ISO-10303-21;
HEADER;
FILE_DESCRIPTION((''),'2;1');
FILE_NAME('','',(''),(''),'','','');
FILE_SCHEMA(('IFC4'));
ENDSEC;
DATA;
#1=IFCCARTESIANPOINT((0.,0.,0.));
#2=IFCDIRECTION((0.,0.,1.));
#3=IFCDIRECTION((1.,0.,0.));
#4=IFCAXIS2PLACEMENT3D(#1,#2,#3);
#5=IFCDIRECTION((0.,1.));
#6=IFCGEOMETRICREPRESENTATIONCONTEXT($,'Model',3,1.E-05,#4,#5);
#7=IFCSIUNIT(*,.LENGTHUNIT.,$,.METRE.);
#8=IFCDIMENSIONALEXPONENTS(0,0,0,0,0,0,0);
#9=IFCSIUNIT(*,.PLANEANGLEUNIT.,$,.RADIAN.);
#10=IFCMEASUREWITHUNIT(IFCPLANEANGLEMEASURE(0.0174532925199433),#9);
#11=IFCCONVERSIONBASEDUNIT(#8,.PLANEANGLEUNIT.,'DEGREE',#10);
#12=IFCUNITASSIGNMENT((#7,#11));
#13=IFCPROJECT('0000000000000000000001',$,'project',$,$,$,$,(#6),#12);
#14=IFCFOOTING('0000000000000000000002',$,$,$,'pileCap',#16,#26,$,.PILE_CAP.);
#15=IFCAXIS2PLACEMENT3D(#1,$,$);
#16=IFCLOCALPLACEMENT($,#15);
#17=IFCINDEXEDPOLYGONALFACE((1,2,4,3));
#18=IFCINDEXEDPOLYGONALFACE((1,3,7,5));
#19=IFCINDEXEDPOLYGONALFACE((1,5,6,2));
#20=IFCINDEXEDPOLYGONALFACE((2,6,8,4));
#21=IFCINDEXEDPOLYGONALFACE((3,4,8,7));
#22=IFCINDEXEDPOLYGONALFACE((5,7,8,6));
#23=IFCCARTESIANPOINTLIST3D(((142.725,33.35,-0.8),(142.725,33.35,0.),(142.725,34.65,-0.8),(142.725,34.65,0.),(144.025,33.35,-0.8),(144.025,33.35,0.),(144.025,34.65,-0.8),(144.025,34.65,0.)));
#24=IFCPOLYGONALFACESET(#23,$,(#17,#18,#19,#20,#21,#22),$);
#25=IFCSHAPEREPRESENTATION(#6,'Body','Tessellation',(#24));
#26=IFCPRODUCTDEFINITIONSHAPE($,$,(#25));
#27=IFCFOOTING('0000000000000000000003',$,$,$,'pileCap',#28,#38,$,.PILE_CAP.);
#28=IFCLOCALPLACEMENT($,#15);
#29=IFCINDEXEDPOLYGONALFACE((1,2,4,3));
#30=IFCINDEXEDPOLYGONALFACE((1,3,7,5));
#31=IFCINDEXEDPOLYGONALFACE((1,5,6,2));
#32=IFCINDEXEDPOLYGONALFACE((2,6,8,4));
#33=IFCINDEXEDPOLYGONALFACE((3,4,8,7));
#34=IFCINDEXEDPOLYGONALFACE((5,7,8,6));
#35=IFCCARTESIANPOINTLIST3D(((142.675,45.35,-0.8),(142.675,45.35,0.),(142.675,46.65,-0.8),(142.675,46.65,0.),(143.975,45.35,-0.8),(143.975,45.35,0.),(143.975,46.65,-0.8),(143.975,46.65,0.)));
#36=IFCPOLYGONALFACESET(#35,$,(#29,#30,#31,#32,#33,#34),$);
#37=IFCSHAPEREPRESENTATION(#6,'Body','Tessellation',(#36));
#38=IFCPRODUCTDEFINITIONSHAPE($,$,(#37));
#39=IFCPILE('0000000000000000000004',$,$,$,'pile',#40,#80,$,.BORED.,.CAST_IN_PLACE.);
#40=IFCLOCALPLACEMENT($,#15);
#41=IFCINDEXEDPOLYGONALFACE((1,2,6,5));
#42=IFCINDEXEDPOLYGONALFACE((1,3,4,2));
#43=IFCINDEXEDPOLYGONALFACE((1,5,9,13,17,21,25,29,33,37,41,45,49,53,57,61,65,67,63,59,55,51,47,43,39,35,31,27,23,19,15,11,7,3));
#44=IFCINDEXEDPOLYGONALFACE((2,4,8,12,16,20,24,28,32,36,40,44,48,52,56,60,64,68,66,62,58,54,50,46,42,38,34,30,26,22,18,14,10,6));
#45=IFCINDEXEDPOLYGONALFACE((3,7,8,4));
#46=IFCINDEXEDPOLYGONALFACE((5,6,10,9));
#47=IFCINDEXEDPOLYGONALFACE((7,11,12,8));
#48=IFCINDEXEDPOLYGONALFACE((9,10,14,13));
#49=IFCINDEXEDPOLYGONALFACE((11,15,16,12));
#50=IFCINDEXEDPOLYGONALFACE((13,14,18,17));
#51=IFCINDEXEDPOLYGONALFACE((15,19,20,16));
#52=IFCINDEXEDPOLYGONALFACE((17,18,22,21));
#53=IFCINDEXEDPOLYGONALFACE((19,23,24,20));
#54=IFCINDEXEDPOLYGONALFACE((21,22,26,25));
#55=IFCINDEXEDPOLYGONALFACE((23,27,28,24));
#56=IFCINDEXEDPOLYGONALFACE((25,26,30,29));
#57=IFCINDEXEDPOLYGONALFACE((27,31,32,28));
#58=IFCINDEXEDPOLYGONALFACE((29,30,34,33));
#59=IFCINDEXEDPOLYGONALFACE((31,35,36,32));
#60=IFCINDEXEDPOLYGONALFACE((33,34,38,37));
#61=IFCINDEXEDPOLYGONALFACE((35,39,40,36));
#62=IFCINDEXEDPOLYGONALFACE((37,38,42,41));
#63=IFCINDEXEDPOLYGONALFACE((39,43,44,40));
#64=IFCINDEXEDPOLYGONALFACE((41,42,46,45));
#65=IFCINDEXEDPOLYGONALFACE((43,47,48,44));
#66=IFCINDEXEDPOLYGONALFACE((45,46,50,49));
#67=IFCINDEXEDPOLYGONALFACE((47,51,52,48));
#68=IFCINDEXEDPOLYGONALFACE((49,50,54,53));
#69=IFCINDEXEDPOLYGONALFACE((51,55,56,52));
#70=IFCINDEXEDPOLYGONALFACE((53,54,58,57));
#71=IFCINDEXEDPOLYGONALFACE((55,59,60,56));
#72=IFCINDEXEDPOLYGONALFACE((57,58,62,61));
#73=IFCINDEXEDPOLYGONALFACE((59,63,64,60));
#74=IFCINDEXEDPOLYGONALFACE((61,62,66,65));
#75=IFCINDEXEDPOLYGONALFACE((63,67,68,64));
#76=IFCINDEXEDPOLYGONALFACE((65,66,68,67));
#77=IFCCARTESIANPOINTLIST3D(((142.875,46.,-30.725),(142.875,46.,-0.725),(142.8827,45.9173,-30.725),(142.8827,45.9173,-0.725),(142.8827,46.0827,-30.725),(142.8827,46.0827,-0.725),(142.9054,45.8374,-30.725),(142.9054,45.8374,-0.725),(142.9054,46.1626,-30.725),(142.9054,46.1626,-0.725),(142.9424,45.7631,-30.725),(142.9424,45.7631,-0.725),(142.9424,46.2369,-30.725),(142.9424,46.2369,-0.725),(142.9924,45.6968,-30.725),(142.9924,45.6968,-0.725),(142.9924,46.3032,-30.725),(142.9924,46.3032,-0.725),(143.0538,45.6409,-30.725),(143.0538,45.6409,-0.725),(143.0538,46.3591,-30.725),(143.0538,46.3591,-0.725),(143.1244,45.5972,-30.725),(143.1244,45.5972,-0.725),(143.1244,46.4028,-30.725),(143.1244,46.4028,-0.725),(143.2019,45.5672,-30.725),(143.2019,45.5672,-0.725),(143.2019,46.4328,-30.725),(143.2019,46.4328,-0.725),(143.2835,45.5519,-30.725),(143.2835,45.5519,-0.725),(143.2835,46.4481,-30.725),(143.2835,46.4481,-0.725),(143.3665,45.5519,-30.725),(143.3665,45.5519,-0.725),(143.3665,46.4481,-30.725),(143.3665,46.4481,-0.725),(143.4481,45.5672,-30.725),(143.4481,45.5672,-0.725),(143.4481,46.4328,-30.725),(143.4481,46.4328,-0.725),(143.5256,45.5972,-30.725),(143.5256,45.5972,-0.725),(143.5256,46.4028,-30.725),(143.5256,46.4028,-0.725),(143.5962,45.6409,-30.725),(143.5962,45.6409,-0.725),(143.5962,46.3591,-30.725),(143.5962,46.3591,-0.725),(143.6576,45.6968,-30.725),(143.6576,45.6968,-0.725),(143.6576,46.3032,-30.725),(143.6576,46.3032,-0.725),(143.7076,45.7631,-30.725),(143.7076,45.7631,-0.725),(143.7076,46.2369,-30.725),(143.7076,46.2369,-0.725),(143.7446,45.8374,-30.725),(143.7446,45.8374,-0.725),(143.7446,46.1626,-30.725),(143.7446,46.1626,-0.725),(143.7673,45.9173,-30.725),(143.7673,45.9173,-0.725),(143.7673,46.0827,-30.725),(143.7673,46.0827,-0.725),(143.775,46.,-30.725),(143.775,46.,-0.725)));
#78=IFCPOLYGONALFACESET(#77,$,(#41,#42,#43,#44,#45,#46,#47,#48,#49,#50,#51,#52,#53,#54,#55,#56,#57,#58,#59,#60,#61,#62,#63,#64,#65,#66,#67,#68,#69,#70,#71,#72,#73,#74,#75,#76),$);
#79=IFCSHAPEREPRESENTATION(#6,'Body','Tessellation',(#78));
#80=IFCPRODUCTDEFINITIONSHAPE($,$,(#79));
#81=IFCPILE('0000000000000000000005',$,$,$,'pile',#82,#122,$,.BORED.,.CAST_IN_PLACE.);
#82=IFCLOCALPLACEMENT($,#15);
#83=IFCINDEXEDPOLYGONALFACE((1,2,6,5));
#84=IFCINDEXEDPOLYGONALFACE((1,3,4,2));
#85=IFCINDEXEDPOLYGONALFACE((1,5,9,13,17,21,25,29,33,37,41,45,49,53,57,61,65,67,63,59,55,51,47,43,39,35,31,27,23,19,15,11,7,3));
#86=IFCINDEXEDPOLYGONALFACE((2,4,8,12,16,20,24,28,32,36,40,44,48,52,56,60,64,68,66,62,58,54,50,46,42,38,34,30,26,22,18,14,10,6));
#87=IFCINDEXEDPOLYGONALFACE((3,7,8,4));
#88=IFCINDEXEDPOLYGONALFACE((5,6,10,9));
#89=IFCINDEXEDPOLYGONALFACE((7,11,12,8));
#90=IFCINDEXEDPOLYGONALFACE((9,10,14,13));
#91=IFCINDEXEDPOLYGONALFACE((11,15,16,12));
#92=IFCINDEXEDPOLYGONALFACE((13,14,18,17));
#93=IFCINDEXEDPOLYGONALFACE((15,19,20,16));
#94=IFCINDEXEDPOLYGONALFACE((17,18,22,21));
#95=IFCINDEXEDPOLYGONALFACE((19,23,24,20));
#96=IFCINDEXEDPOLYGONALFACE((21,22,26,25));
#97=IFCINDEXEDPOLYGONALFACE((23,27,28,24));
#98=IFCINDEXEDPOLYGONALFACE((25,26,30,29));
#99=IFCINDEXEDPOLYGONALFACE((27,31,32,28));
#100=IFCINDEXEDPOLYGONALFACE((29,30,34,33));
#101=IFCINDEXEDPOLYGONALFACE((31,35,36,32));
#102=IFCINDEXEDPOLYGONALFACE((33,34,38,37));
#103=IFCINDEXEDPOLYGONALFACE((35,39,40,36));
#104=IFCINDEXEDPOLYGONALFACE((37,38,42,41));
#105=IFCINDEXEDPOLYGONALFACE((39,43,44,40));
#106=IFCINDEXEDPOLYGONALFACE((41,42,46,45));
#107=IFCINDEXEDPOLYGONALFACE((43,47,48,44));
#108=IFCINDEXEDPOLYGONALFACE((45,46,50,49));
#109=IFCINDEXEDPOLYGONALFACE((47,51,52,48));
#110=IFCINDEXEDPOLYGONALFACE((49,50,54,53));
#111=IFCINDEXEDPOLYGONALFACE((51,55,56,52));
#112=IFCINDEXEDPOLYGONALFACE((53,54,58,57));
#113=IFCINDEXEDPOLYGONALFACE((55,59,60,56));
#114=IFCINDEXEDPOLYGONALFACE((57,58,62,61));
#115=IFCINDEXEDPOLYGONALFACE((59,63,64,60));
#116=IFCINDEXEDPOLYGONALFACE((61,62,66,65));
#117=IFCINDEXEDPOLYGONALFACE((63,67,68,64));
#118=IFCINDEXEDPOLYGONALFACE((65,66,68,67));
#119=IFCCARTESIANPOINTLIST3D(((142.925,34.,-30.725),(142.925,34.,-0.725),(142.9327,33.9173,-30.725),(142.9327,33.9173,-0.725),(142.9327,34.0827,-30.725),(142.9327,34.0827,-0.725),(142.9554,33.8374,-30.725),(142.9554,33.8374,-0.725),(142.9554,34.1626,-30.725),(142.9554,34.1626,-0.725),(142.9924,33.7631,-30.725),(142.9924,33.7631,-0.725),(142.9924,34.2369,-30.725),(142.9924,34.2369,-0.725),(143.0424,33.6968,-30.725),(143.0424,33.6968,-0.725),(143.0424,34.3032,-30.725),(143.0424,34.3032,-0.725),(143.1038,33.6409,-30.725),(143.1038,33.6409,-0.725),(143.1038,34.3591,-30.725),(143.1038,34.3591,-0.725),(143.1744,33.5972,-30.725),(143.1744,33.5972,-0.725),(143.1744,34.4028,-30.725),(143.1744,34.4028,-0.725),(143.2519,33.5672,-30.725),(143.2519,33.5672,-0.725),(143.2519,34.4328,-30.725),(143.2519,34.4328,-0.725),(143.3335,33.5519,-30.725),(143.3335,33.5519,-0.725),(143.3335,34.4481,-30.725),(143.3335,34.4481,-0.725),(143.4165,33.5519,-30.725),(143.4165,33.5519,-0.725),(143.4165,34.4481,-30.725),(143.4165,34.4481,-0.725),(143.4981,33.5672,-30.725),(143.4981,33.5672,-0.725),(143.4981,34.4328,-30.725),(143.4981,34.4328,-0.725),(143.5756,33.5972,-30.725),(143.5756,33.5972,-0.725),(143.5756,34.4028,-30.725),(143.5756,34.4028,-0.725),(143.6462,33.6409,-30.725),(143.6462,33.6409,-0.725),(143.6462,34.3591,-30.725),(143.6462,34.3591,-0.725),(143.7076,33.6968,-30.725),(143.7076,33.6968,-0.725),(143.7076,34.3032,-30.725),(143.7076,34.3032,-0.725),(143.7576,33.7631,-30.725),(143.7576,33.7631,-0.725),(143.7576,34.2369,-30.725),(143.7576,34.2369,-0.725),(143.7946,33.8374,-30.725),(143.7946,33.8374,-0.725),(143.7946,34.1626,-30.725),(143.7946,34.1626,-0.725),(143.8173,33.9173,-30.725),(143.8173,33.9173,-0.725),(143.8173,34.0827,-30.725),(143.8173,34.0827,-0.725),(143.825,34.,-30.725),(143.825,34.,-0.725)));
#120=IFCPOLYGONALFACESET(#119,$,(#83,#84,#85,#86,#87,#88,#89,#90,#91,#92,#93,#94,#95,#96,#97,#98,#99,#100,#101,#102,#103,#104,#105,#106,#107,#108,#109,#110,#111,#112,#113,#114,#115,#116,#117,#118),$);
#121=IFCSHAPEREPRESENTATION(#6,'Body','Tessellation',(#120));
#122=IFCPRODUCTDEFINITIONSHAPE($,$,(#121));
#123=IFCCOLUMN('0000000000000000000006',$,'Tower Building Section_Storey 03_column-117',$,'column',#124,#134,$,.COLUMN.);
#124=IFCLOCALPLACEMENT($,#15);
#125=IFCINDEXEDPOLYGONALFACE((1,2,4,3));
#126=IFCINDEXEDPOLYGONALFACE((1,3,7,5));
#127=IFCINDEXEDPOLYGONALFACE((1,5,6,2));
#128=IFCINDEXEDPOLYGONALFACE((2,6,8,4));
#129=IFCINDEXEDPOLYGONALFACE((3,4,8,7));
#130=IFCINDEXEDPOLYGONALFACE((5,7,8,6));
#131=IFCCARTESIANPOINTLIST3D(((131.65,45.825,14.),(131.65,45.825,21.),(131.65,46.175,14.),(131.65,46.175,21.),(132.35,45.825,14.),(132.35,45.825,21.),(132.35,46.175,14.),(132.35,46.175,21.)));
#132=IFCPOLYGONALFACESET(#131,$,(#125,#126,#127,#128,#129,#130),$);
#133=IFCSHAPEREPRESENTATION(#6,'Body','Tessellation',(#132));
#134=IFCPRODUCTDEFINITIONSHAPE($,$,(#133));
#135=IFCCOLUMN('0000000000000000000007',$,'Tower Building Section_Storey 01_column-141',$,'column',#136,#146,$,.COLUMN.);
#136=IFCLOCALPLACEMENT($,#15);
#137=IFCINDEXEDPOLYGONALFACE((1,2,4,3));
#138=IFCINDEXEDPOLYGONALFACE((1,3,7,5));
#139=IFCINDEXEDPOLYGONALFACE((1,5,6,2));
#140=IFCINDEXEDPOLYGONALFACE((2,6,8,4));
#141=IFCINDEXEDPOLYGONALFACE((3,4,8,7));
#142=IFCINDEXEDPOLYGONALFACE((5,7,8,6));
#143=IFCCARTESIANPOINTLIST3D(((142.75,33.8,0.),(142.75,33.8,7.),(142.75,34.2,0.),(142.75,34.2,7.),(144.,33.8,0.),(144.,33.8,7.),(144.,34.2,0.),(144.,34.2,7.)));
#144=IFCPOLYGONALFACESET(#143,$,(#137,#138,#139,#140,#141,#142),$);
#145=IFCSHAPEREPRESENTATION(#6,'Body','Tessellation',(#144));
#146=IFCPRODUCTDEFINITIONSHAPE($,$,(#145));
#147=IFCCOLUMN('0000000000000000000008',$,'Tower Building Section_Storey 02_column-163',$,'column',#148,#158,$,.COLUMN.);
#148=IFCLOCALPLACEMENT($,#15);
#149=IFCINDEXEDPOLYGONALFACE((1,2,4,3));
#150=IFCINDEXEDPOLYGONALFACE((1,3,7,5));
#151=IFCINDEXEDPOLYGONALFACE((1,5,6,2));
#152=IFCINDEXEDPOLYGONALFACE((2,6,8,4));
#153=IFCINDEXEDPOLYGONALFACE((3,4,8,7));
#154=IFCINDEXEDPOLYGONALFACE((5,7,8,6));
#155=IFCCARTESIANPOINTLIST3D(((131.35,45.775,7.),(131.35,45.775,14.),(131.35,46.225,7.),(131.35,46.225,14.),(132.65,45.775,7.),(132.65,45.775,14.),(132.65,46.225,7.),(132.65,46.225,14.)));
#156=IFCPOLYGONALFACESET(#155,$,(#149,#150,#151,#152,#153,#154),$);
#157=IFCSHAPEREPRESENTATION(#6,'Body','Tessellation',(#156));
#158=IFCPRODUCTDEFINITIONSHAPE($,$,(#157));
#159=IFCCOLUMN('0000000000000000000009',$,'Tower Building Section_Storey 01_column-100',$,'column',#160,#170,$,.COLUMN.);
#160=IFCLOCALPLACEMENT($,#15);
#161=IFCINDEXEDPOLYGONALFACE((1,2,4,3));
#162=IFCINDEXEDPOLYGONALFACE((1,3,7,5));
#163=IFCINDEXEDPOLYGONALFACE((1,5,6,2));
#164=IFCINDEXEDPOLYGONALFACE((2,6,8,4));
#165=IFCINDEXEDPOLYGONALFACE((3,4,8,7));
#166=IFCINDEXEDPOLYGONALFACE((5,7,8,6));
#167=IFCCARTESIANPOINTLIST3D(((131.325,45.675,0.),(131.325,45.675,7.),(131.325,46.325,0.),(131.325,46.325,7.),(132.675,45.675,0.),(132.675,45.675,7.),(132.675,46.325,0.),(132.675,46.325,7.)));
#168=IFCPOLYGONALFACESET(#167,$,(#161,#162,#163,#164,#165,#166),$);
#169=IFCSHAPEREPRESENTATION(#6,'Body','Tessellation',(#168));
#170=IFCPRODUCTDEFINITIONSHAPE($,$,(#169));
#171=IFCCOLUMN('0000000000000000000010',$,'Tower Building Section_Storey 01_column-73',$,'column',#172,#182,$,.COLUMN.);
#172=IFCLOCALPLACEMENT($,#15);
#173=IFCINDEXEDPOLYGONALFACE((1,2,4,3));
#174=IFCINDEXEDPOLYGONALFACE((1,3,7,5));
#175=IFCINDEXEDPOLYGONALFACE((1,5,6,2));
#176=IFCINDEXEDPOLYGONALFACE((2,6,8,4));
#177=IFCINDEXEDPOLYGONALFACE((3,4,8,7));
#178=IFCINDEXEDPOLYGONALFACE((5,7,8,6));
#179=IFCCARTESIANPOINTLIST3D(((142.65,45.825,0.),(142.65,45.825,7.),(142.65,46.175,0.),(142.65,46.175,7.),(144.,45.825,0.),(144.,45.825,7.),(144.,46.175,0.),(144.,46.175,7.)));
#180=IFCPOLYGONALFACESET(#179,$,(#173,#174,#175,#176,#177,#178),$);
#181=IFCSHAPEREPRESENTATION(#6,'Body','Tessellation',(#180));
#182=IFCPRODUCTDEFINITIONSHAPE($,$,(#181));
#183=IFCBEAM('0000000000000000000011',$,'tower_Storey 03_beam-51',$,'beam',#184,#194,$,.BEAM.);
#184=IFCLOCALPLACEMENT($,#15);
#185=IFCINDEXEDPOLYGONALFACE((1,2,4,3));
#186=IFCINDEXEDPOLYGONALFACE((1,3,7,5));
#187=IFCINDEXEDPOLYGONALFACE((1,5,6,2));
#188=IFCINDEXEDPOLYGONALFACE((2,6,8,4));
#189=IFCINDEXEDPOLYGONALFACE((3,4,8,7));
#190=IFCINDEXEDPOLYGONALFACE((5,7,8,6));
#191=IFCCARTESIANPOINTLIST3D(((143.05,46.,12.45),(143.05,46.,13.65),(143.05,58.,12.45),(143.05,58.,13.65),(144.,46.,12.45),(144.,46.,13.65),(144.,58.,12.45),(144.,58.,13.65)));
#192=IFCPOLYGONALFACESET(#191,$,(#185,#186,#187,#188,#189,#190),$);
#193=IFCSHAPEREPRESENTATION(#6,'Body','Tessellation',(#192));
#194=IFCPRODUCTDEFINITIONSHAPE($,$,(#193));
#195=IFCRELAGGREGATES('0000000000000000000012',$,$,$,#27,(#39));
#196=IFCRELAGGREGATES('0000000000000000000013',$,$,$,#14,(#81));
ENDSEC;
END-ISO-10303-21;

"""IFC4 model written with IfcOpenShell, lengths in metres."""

from ifc_helpers import new_model, entity, si_unit, converted_unit, direction, frame, origin_with_axes, place, context, project, polyline, circle_curve, parameter, trimmed, segment, composite_curve, outline, extrude, element, aggregate, save


model = new_model("IFC4")

# Units and contexts
model_context = context("Model", 3, precision=1e-05, world=origin_with_axes(), true_north=direction((0.0, 1.0)))
ifc_project = project(units=[si_unit("LENGTHUNIT", "METRE"), converted_unit("PLANEANGLEUNIT", "DEGREE", entity("IfcPlaneAngleMeasure", 0.0174532925199433), si_unit("PLANEANGLEUNIT", "RADIAN"), dimensions=[0, 0, 0, 0, 0, 0, 0])], contexts=[model_context])

# Footing
placement_1 = place(None, origin_with_axes())
placement_2 = place(placement_1, origin_with_axes())
footing_1_placement = place(placement_2, frame((143.375, 34.0, -0.8), z_axis=(0.0, 0.0, 1.0), x_axis=(1.0, 0.0, 0.0)))
footing_1 = element("IfcFooting", 1, at=footing_1_placement, ObjectType="pileCap", PredefinedType="PILE_CAP", context=model_context, body=[
    extrude(outline(polyline([(0.65, -0.65, 0.0), (0.65, 0.65, 0.0), (-0.65, 0.65, 0.0), (-0.65, -0.65, 0.0), (0.65, -0.65, 0.0)])), origin_with_axes(), (0.0, 0.0, 1.0), 0.8),
])

# Footing, pile
footing_2_placement = place(placement_2, frame((143.325, 46.0, -0.8), z_axis=(0.0, 0.0, 1.0), x_axis=(1.0, 0.0, 0.0)))
footing_2 = element("IfcFooting", 2, at=footing_2_placement, ObjectType="pileCap", PredefinedType="PILE_CAP", context=model_context, body=[
    extrude(outline(polyline([(0.65, -0.65, 0.0), (0.65, 0.65, 0.0), (-0.65, 0.65, 0.0), (-0.65, -0.65, 0.0), (0.65, -0.65, 0.0)])), origin_with_axes(), (0.0, 0.0, 1.0), 0.8),
])
pile_1_placement = place(footing_2_placement, frame((0.0, 0.0, -29.925), z_axis=(0.0, 0.0, 1.0), x_axis=(1.0, 0.0, 0.0)))
pile_1 = element("IfcPile", 3, at=pile_1_placement, ObjectType="pile", ConstructionType="CAST_IN_PLACE", PredefinedType="BORED", context=model_context, body=[
    extrude(outline(composite_curve([segment(trimmed(circle_curve(origin_with_axes(), 0.45), [parameter(0.0)], [parameter(360.0)], True, "PARAMETER"), True, "CONTINUOUS")], self_intersect=False)), origin_with_axes(), (0.0, 0.0, 1.0), 30.0),
])
aggregate(footing_2, [pile_1])

# Pile
pile_2_placement = place(footing_1_placement, frame((0.0, 0.0, -29.925), z_axis=(0.0, 0.0, 1.0), x_axis=(1.0, 0.0, 0.0)))
pile_2 = element("IfcPile", 4, at=pile_2_placement, ObjectType="pile", ConstructionType="CAST_IN_PLACE", PredefinedType="BORED", context=model_context, body=[
    extrude(outline(composite_curve([segment(trimmed(circle_curve(origin_with_axes(), 0.45), [parameter(0.0)], [parameter(360.0)], True, "PARAMETER"), True, "CONTINUOUS")], self_intersect=False)), origin_with_axes(), (0.0, 0.0, 1.0), 30.0),
])
aggregate(footing_1, [pile_2])

# Columns
placement_3 = place(placement_1, frame((0.0, 0.0, 14.0), z_axis=(0.0, 0.0, 1.0), x_axis=(1.0, 0.0, 0.0)))
column_1_placement = place(placement_3, frame((132.0, 46.0, 0.0), z_axis=(0.0, 0.0, 1.0), x_axis=(1.0, 0.0, 0.0)))
element("IfcColumn", 5, at=column_1_placement, Name="Tower Building Section_Storey 03_column-117", ObjectType="column", PredefinedType="COLUMN", context=model_context, body=[
    extrude(outline(polyline([(-0.35, -0.175, 0.0), (0.35, -0.175, 0.0), (0.35, 0.175, 0.0), (-0.35, 0.175, 0.0), (-0.35, -0.175, 0.0)])), origin_with_axes(), (0.0, 0.0, 1.0), 7.0),
])
column_2_placement = place(placement_2, frame((143.375, 34.0, 0.0), z_axis=(0.0, 0.0, 1.0), x_axis=(1.0, 0.0, 0.0)))
element("IfcColumn", 6, at=column_2_placement, Name="Tower Building Section_Storey 01_column-141", ObjectType="column", PredefinedType="COLUMN", context=model_context, body=[
    extrude(outline(polyline([(-0.625, -0.2, 0.0), (0.625, -0.2, 0.0), (0.625, 0.2, 0.0), (-0.625, 0.2, 0.0), (-0.625, -0.2, 0.0)])), origin_with_axes(), (0.0, 0.0, 1.0), 7.0),
])
placement_4 = place(placement_1, frame((0.0, 0.0, 7.0), z_axis=(0.0, 0.0, 1.0), x_axis=(1.0, 0.0, 0.0)))
column_3_placement = place(placement_4, frame((132.0, 46.0, 0.0), z_axis=(0.0, 0.0, 1.0), x_axis=(1.0, 0.0, 0.0)))
element("IfcColumn", 7, at=column_3_placement, Name="Tower Building Section_Storey 02_column-163", ObjectType="column", PredefinedType="COLUMN", context=model_context, body=[
    extrude(outline(polyline([(-0.65, -0.225, 0.0), (0.65, -0.225, 0.0), (0.65, 0.225, 0.0), (-0.65, 0.225, 0.0), (-0.65, -0.225, 0.0)])), origin_with_axes(), (0.0, 0.0, 1.0), 7.0),
])
column_4_placement = place(placement_2, frame((132.0, 46.0, 0.0), z_axis=(0.0, 0.0, 1.0), x_axis=(1.0, 0.0, 0.0)))
element("IfcColumn", 8, at=column_4_placement, Name="Tower Building Section_Storey 01_column-100", ObjectType="column", PredefinedType="COLUMN", context=model_context, body=[
    extrude(outline(polyline([(-0.675, -0.325, 0.0), (0.675, -0.325, 0.0), (0.675, 0.325, 0.0), (-0.675, 0.325, 0.0), (-0.675, -0.325, 0.0)])), origin_with_axes(), (0.0, 0.0, 1.0), 7.0),
])
column_5_placement = place(placement_2, frame((143.325, 46.0, 0.0), z_axis=(0.0, 0.0, 1.0), x_axis=(1.0, 0.0, 0.0)))
element("IfcColumn", 9, at=column_5_placement, Name="Tower Building Section_Storey 01_column-73", ObjectType="column", PredefinedType="COLUMN", context=model_context, body=[
    extrude(outline(polyline([(-0.675, -0.175, 0.0), (0.675, -0.175, 0.0), (0.675, 0.175, 0.0), (-0.675, 0.175, 0.0), (-0.675, -0.175, 0.0)])), origin_with_axes(), (0.0, 0.0, 1.0), 7.0),
])

# Beam
beam_1_placement = place(placement_3, frame((143.525, 46.0, -0.95), z_axis=(0.0, 1.0, 0.0), x_axis=(-1.0, 0.0, 0.0)))
element("IfcBeam", 10, at=beam_1_placement, Name="tower_Storey 03_beam-51", ObjectType="beam", PredefinedType="BEAM", context=model_context, body=[
    extrude(outline(polyline([(0.475, 0.6, 0.0), (-0.475, 0.6, 0.0), (-0.475, -0.6, 0.0), (0.475, -0.6, 0.0), (0.475, 0.6, 0.0)])), origin_with_axes(), (0.0, 0.0, 1.0), 12.0),
])

save(model, "model.ifc")
